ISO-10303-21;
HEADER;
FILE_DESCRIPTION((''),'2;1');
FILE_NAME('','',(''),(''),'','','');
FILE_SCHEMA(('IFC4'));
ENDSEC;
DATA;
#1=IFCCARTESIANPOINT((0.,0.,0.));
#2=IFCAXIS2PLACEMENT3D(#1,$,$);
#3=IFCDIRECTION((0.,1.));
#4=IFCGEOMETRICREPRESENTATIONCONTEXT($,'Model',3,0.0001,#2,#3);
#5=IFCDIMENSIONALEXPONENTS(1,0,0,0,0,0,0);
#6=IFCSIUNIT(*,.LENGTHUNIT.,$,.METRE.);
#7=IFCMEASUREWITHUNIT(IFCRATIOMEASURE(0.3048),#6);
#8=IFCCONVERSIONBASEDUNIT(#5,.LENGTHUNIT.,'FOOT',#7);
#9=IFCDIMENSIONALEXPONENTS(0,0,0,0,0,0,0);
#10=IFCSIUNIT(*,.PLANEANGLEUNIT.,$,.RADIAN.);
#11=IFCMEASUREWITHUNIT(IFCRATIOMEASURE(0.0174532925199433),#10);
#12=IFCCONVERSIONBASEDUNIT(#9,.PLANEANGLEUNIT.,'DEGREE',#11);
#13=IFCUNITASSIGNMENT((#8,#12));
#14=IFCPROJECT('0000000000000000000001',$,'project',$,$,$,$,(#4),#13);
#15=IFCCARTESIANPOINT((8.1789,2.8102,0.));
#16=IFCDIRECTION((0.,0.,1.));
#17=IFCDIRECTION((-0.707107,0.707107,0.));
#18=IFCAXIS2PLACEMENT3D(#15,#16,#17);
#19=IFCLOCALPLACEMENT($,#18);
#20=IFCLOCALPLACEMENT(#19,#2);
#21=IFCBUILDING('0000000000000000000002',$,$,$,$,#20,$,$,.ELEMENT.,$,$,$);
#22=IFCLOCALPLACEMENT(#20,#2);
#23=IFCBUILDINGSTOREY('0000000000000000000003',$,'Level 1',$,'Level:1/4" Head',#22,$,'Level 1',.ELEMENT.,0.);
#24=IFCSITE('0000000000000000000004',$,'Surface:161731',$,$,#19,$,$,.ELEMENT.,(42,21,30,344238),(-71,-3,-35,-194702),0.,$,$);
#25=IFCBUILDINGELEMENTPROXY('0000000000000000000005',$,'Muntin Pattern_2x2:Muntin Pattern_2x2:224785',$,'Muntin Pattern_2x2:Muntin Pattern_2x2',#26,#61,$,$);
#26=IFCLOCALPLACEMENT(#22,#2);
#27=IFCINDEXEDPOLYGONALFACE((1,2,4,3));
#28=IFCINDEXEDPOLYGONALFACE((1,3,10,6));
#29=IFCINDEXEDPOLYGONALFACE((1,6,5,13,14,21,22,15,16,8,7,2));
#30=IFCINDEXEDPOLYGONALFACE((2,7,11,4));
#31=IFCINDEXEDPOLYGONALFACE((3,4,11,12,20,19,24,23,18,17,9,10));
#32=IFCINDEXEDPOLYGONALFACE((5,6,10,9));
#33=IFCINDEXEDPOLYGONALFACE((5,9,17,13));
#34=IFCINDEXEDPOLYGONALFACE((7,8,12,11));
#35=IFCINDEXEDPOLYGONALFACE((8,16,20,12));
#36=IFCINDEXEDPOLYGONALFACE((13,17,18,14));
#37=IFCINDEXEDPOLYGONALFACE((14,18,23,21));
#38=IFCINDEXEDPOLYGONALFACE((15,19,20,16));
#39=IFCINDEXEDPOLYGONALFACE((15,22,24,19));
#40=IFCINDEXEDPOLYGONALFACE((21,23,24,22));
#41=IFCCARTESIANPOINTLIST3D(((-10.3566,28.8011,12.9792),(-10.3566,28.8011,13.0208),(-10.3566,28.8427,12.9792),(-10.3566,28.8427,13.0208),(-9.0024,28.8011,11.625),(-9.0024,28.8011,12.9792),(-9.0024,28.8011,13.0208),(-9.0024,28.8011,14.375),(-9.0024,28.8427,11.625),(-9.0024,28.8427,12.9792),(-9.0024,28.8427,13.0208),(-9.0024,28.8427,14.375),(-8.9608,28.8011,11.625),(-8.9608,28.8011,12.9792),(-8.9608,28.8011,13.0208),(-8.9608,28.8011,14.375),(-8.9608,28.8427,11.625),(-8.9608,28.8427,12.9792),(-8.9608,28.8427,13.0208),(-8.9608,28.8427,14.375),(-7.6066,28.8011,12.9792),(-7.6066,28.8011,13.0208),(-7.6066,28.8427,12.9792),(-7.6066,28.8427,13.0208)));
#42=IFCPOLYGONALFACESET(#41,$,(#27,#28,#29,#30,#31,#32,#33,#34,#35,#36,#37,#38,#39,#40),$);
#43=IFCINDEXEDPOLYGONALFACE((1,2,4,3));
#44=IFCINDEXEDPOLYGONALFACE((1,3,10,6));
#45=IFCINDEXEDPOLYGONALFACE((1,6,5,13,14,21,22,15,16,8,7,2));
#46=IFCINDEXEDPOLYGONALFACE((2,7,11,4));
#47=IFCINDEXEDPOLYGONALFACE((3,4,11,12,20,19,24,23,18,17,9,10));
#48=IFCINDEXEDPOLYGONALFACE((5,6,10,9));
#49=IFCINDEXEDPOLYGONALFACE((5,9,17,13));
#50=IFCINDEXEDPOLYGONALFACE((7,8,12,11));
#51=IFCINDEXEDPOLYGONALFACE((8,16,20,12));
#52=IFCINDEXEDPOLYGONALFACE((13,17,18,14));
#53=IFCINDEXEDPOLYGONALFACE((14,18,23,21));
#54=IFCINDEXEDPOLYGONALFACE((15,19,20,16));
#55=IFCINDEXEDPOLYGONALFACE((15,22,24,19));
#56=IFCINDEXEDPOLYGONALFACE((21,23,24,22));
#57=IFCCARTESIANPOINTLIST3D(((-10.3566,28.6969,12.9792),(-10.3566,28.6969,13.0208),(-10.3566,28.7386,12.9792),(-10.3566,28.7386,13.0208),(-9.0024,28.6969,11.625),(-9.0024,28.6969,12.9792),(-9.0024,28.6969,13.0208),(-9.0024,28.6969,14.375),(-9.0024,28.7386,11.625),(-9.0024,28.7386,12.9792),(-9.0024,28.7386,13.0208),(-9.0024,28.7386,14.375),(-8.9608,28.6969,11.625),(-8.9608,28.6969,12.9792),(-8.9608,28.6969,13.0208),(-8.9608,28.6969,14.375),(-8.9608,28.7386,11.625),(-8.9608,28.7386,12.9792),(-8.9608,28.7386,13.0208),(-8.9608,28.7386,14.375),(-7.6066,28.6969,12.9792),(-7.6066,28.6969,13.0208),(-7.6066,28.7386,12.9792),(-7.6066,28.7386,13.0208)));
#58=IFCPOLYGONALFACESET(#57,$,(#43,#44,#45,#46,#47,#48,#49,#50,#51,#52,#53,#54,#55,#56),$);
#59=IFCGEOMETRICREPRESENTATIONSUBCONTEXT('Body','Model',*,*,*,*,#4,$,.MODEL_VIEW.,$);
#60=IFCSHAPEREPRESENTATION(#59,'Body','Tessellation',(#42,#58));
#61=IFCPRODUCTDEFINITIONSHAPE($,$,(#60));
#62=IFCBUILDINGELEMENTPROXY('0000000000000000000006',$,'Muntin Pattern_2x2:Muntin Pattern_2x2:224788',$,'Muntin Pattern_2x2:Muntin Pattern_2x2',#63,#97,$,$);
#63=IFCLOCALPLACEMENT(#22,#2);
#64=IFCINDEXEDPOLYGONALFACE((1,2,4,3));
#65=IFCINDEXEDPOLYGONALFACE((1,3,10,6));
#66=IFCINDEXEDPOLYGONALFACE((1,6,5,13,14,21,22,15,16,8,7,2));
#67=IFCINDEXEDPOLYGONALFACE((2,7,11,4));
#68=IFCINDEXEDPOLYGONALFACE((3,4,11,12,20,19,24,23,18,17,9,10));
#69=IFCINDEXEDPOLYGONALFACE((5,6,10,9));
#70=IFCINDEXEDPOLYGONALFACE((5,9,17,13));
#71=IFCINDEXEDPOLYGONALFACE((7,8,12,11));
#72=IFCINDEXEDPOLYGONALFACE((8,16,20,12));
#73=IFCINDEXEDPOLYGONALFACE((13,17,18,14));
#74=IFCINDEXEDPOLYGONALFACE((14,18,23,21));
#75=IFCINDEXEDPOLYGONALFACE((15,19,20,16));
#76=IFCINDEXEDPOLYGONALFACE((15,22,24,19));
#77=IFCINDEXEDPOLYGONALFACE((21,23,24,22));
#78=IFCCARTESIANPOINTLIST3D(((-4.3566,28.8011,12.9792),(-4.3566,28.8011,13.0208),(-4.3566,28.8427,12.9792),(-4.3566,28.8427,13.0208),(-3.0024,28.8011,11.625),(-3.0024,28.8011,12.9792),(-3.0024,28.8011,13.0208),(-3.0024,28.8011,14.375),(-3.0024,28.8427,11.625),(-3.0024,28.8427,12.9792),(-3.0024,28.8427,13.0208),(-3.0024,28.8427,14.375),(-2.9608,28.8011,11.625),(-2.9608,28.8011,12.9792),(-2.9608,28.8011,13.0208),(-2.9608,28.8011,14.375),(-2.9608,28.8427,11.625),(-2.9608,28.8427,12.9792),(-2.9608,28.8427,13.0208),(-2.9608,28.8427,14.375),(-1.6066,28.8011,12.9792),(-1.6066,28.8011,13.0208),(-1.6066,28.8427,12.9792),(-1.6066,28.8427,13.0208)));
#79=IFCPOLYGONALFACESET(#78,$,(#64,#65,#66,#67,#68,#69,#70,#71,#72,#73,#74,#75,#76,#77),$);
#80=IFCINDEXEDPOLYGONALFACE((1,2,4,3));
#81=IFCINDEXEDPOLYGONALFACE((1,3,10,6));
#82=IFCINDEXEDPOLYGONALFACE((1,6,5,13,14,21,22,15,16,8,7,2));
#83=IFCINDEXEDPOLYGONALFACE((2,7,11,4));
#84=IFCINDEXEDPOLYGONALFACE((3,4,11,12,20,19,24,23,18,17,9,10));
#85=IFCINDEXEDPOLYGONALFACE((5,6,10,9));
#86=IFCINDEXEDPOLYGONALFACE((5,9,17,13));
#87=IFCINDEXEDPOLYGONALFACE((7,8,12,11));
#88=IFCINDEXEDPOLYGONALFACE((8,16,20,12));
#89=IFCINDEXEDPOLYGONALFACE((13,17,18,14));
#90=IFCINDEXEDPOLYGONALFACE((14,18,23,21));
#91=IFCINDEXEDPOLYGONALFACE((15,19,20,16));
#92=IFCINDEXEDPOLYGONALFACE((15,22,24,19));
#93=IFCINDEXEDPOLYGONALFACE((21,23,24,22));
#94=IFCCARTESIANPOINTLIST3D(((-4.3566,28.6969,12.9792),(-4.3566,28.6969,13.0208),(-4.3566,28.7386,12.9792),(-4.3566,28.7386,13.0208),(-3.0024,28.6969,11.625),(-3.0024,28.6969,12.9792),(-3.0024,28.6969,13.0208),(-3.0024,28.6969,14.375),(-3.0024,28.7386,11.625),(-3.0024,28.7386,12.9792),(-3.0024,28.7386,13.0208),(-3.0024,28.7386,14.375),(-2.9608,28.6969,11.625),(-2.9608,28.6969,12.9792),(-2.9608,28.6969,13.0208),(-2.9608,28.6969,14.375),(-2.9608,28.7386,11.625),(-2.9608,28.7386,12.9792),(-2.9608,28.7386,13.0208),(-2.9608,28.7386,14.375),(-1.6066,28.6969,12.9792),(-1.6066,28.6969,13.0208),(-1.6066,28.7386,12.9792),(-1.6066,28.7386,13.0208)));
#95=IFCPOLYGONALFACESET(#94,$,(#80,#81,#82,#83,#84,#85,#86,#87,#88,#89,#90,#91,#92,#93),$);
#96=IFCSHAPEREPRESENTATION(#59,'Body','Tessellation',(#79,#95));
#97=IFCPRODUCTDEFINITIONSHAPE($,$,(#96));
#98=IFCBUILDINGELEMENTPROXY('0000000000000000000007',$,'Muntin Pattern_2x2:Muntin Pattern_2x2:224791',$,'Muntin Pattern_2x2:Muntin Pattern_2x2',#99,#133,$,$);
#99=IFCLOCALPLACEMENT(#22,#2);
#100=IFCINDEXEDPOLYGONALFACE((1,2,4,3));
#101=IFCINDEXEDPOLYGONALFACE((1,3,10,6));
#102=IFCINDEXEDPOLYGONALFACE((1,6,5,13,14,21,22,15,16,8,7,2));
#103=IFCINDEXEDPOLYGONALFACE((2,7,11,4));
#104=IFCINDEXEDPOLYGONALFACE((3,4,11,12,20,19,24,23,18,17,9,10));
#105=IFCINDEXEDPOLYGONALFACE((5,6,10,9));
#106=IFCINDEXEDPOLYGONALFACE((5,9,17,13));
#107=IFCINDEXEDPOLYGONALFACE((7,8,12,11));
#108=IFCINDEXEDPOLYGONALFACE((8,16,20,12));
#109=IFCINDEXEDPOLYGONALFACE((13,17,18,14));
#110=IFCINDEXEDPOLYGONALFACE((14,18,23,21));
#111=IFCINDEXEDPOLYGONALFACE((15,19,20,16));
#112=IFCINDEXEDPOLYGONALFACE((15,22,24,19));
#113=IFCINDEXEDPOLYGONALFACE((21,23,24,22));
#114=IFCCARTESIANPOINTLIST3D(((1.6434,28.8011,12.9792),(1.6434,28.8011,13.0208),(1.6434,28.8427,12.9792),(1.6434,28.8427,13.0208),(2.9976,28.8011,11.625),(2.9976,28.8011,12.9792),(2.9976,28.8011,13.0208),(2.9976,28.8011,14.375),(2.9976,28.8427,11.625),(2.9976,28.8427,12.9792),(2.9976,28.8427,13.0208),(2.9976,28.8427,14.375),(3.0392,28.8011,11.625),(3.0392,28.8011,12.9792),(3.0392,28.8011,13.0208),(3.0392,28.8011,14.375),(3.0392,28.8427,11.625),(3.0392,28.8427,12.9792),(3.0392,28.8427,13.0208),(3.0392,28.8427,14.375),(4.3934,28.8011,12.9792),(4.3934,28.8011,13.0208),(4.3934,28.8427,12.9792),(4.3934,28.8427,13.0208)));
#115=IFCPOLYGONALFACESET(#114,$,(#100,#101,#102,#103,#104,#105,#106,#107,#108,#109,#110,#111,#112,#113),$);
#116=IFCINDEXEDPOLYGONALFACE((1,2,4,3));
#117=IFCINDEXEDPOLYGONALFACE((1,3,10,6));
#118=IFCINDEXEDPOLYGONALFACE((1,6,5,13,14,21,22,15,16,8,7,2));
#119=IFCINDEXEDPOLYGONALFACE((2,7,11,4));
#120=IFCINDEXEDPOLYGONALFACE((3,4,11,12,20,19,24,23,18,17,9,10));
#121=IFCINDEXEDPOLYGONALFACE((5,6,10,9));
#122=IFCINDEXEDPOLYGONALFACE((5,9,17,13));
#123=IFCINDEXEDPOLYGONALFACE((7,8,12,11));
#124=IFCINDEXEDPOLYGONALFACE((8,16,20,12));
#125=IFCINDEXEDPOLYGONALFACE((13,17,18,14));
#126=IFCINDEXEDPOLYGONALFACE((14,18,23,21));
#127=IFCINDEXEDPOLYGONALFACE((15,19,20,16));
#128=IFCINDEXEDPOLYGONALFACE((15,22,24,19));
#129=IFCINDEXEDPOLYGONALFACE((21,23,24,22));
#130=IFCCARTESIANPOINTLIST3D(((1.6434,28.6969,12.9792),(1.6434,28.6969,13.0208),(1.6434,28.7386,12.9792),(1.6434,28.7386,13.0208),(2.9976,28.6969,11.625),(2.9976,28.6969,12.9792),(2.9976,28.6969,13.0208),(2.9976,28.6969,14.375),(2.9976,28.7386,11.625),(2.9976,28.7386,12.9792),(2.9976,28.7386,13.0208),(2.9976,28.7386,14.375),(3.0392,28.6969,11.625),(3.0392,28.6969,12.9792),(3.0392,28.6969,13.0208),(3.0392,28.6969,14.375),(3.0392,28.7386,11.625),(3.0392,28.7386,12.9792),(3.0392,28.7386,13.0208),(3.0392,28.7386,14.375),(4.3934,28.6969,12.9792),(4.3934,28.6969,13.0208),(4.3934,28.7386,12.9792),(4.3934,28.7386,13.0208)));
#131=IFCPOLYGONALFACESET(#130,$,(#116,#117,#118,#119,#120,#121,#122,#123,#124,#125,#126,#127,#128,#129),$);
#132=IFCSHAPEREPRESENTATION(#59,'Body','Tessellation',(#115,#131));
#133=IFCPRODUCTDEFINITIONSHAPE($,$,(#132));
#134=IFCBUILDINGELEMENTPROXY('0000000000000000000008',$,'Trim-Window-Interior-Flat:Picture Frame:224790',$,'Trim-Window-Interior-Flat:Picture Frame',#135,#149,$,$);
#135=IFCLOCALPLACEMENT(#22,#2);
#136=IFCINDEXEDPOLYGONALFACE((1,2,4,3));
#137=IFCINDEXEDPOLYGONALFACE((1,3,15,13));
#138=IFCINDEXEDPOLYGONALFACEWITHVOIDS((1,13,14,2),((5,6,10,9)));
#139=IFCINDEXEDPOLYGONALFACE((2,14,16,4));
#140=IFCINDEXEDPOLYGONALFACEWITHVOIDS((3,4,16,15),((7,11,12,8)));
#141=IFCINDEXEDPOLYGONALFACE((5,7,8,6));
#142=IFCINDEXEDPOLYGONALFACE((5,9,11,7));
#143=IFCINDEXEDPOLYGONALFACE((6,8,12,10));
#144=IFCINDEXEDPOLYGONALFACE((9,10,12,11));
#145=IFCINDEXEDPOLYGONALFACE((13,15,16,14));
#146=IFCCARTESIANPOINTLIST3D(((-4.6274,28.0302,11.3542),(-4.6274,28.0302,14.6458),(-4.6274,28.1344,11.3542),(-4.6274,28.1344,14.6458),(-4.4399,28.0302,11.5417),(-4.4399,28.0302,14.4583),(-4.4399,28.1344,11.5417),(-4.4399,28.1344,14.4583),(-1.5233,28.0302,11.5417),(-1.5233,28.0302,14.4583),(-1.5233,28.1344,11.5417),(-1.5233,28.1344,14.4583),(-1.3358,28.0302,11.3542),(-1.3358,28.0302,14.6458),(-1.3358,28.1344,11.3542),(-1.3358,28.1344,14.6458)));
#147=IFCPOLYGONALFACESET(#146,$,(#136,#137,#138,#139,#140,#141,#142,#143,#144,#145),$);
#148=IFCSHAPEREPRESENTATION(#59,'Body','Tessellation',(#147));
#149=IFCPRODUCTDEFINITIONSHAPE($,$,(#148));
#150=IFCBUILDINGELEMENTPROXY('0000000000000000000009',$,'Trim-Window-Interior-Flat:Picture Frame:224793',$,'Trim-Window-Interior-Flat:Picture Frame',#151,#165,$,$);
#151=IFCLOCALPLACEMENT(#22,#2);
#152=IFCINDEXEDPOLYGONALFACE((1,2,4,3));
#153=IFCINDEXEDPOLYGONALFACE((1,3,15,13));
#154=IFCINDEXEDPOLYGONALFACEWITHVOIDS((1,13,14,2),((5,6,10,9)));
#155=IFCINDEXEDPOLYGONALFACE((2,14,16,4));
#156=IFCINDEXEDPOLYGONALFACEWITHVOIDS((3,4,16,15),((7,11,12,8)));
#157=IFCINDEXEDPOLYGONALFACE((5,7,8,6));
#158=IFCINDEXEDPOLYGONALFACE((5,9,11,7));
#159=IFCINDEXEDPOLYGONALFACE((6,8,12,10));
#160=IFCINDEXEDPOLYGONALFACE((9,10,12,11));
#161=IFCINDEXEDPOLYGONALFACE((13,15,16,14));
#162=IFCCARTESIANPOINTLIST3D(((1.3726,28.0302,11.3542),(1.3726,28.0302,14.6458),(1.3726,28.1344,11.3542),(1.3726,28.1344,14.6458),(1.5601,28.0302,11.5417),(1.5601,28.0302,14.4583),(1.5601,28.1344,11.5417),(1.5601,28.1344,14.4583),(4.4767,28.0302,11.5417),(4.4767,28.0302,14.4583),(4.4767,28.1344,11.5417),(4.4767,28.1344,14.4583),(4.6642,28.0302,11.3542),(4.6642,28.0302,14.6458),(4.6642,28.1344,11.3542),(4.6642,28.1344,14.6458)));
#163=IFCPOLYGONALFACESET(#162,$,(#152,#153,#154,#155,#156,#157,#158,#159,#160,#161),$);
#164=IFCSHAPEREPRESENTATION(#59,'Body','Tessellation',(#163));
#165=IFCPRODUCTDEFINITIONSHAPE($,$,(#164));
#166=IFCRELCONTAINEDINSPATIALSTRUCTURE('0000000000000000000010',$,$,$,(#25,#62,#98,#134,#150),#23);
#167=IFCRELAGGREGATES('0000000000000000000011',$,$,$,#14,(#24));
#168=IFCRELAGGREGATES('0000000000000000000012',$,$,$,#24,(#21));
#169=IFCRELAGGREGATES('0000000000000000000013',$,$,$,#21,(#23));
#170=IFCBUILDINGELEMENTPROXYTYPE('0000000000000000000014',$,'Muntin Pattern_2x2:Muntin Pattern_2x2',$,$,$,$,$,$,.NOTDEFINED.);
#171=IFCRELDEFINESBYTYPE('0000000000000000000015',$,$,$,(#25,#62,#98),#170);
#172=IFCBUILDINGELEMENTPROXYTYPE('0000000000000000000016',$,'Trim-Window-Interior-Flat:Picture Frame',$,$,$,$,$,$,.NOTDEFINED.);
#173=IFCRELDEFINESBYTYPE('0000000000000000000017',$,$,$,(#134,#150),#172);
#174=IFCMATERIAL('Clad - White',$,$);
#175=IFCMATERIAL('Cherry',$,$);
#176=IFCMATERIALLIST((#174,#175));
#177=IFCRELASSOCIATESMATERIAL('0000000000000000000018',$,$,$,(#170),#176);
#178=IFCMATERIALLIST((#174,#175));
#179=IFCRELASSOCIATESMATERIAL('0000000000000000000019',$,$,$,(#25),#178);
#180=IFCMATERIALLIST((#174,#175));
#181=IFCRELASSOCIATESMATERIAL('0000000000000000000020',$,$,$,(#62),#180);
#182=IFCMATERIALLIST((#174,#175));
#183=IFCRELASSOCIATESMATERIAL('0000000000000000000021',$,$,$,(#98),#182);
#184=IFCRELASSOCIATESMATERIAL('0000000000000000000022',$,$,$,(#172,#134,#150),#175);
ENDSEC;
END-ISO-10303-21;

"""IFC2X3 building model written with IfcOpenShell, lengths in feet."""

from ifc_helpers import new_model, entity, si_unit, converted_unit, direction, frame, origin, place, context, subcontext, project, spatial, polyline, outline, extrude, source, transform, mapped, material, material_list, type_object, type_shapes, element, save


model = new_model("IFC2X3")

# Units and contexts
model_context = context("Model", 3, precision=0.0001, world=origin(), true_north=direction((0.0, 1.0)))
body_context = subcontext(model_context, "Body", "Model", "MODEL_VIEW")
ifc_project = project(units=[converted_unit("LENGTHUNIT", "FOOT", entity("IfcRatioMeasure", 0.3048), si_unit("LENGTHUNIT", "METRE"), dimensions=[1, 0, 0, 0, 0, 0, 0]), converted_unit("PLANEANGLEUNIT", "DEGREE", entity("IfcRatioMeasure", 0.0174532925199433), si_unit("PLANEANGLEUNIT", "RADIAN"), dimensions=[0, 0, 0, 0, 0, 0, 0])], contexts=[model_context])

# Site, building, storey
site_placement = place(None, frame((8.1789, 2.8102, 0.0), z_axis=(0.0, 0.0, 1.0), x_axis=(-0.707107, 0.707107, 0.0)))
site = spatial("IfcSite", under=ifc_project, at=site_placement, Name="Surface:161731", CompositionType="ELEMENT", RefLatitude=(42, 21, 30, 344238), RefLongitude=(-71, -3, -35, -194702), RefElevation=0.0)
building_placement = place(site_placement, origin())
building = spatial("IfcBuilding", under=site, at=building_placement, CompositionType="ELEMENT")
storey_placement = place(building_placement, origin())
storey = spatial("IfcBuildingStorey", under=building, at=storey_placement, Name="Level 1", ObjectType="Level:1/4\" Head", LongName="Level 1", CompositionType="ELEMENT", Elevation=0.0)

# Building element proxies
ifc_material_1 = material(Name="Clad - White")
ifc_material_2 = material(Name="Cherry")
ifc_material_list_1 = material_list([ifc_material_1, ifc_material_2])
ifc_material_list_2 = material_list([ifc_material_1, ifc_material_2])
building_element_proxy_type_1 = type_object("IfcBuildingElementProxyType", Name="Muntin Pattern_2x2:Muntin Pattern_2x2", PredefinedType="NOTDEFINED", material=ifc_material_list_2)
shared_shape_1 = source(origin(), body_context, "Body", "SweptSolid", [
    extrude(outline(polyline([(0.0208, -0.0208), (1.375, -0.0208), (1.375, 0.0208), (0.0208, 0.0208), (0.0208, 1.375), (-0.0208, 1.375), (-0.0208, 0.0208), (-1.375, 0.0208), (-1.375, -0.0208), (-0.0208, -0.0208), (-0.0208, -1.375), (0.0208, -1.375), (0.0208, -0.0208)])), frame((0.0, -0.0729, 1.375), z_axis=(0.0, 1.0, 0.0), x_axis=(0.0, 0.0, 1.0)), (0.0, 0.0, 1.0), 0.0417),
    extrude(outline(polyline([(0.0208, -0.0208), (1.375, -0.0208), (1.375, 0.0208), (0.0208, 0.0208), (0.0208, 1.375), (-0.0208, 1.375), (-0.0208, 0.0208), (-1.375, 0.0208), (-1.375, -0.0208), (-0.0208, -0.0208), (-0.0208, -1.375), (0.0208, -1.375), (0.0208, -0.0208)])), frame((0.0, 0.0313, 1.375), z_axis=(0.0, 1.0, 0.0), x_axis=(0.0, 0.0, 1.0)), (0.0, 0.0, 1.0), 0.0417),
])
type_shapes(building_element_proxy_type_1, [shared_shape_1])
proxy_1_placement = place(storey_placement, frame((-8.9816, 28.7698, 11.625), z_axis=(0.0, 0.0, 1.0), x_axis=(-1.0, 0.0, 0.0)))
element("IfcBuildingElementProxy", 1, at=proxy_1_placement, inside=storey, type_object=building_element_proxy_type_1, material=ifc_material_list_1, Name="Muntin Pattern_2x2:Muntin Pattern_2x2:224785", ObjectType="Muntin Pattern_2x2:Muntin Pattern_2x2", context=body_context, shape_type="MappedRepresentation", body=[
    mapped(shared_shape_1, transform((0.0, 0.0, 0.0), scale=1.0)),
])
ifc_material_list_3 = material_list([ifc_material_1, ifc_material_2])
proxy_2_placement = place(storey_placement, frame((-2.9816, 28.7698, 11.625), z_axis=(0.0, 0.0, 1.0), x_axis=(-1.0, 0.0, 0.0)))
element("IfcBuildingElementProxy", 2, at=proxy_2_placement, inside=storey, type_object=building_element_proxy_type_1, material=ifc_material_list_3, Name="Muntin Pattern_2x2:Muntin Pattern_2x2:224788", ObjectType="Muntin Pattern_2x2:Muntin Pattern_2x2", context=body_context, shape_type="MappedRepresentation", body=[
    mapped(shared_shape_1, transform((0.0, 0.0, 0.0), scale=1.0)),
])
ifc_material_list_4 = material_list([ifc_material_1, ifc_material_2])
proxy_3_placement = place(storey_placement, frame((3.0184, 28.7698, 11.625), z_axis=(0.0, 0.0, 1.0), x_axis=(-1.0, 0.0, 0.0)))
element("IfcBuildingElementProxy", 3, at=proxy_3_placement, inside=storey, type_object=building_element_proxy_type_1, material=ifc_material_list_4, Name="Muntin Pattern_2x2:Muntin Pattern_2x2:224791", ObjectType="Muntin Pattern_2x2:Muntin Pattern_2x2", context=body_context, shape_type="MappedRepresentation", body=[
    mapped(shared_shape_1, transform((0.0, 0.0, 0.0), scale=1.0)),
])
building_element_proxy_type_2 = type_object("IfcBuildingElementProxyType", Name="Trim-Window-Interior-Flat:Picture Frame", PredefinedType="NOTDEFINED", material=ifc_material_2)
shared_shape_2 = source(origin(), body_context, "Body", "SweptSolid", [
    extrude(outline(polyline([(-1.6458, -1.6458), (1.6458, -1.6458), (1.6458, 1.6458), (-1.6458, 1.6458), (-1.6458, -1.6458)]), holes=[polyline([(-1.4583, -1.4583), (-1.4583, 1.4583), (1.4583, 1.4583), (1.4583, -1.4583), (-1.4583, -1.4583)])]), frame((0.0, -1.5, 0.0), z_axis=(0.0, 0.0, 1.0), x_axis=(-1.0, 0.0, 0.0)), (0.0, 0.0, 1.0), 0.1042),
])
type_shapes(building_element_proxy_type_2, [shared_shape_2])
for number, where, z_axis, x_axis, name in (
    (4, (-2.9816, 28.1344, 14.5), (0.0, -1.0, 0.0), (1.0, 0.0, 0.0), "Trim-Window-Interior-Flat:Picture Frame:224790"),
    (5, (3.0184, 28.1344, 14.5), (0.0, -1.0, 0.0), (1.0, 0.0, 0.0), "Trim-Window-Interior-Flat:Picture Frame:224793"),
):
    element("IfcBuildingElementProxy", number, at=place(storey_placement, frame(where, z_axis=z_axis, x_axis=x_axis)), inside=storey, type_object=building_element_proxy_type_2, material=ifc_material_2, Name=name, ObjectType="Trim-Window-Interior-Flat:Picture Frame", context=body_context, shape_type="MappedRepresentation", body=[
        mapped(shared_shape_2, transform((0.0, 0.0, 0.0), scale=1.0)),
    ])

save(model, "model.ifc")
